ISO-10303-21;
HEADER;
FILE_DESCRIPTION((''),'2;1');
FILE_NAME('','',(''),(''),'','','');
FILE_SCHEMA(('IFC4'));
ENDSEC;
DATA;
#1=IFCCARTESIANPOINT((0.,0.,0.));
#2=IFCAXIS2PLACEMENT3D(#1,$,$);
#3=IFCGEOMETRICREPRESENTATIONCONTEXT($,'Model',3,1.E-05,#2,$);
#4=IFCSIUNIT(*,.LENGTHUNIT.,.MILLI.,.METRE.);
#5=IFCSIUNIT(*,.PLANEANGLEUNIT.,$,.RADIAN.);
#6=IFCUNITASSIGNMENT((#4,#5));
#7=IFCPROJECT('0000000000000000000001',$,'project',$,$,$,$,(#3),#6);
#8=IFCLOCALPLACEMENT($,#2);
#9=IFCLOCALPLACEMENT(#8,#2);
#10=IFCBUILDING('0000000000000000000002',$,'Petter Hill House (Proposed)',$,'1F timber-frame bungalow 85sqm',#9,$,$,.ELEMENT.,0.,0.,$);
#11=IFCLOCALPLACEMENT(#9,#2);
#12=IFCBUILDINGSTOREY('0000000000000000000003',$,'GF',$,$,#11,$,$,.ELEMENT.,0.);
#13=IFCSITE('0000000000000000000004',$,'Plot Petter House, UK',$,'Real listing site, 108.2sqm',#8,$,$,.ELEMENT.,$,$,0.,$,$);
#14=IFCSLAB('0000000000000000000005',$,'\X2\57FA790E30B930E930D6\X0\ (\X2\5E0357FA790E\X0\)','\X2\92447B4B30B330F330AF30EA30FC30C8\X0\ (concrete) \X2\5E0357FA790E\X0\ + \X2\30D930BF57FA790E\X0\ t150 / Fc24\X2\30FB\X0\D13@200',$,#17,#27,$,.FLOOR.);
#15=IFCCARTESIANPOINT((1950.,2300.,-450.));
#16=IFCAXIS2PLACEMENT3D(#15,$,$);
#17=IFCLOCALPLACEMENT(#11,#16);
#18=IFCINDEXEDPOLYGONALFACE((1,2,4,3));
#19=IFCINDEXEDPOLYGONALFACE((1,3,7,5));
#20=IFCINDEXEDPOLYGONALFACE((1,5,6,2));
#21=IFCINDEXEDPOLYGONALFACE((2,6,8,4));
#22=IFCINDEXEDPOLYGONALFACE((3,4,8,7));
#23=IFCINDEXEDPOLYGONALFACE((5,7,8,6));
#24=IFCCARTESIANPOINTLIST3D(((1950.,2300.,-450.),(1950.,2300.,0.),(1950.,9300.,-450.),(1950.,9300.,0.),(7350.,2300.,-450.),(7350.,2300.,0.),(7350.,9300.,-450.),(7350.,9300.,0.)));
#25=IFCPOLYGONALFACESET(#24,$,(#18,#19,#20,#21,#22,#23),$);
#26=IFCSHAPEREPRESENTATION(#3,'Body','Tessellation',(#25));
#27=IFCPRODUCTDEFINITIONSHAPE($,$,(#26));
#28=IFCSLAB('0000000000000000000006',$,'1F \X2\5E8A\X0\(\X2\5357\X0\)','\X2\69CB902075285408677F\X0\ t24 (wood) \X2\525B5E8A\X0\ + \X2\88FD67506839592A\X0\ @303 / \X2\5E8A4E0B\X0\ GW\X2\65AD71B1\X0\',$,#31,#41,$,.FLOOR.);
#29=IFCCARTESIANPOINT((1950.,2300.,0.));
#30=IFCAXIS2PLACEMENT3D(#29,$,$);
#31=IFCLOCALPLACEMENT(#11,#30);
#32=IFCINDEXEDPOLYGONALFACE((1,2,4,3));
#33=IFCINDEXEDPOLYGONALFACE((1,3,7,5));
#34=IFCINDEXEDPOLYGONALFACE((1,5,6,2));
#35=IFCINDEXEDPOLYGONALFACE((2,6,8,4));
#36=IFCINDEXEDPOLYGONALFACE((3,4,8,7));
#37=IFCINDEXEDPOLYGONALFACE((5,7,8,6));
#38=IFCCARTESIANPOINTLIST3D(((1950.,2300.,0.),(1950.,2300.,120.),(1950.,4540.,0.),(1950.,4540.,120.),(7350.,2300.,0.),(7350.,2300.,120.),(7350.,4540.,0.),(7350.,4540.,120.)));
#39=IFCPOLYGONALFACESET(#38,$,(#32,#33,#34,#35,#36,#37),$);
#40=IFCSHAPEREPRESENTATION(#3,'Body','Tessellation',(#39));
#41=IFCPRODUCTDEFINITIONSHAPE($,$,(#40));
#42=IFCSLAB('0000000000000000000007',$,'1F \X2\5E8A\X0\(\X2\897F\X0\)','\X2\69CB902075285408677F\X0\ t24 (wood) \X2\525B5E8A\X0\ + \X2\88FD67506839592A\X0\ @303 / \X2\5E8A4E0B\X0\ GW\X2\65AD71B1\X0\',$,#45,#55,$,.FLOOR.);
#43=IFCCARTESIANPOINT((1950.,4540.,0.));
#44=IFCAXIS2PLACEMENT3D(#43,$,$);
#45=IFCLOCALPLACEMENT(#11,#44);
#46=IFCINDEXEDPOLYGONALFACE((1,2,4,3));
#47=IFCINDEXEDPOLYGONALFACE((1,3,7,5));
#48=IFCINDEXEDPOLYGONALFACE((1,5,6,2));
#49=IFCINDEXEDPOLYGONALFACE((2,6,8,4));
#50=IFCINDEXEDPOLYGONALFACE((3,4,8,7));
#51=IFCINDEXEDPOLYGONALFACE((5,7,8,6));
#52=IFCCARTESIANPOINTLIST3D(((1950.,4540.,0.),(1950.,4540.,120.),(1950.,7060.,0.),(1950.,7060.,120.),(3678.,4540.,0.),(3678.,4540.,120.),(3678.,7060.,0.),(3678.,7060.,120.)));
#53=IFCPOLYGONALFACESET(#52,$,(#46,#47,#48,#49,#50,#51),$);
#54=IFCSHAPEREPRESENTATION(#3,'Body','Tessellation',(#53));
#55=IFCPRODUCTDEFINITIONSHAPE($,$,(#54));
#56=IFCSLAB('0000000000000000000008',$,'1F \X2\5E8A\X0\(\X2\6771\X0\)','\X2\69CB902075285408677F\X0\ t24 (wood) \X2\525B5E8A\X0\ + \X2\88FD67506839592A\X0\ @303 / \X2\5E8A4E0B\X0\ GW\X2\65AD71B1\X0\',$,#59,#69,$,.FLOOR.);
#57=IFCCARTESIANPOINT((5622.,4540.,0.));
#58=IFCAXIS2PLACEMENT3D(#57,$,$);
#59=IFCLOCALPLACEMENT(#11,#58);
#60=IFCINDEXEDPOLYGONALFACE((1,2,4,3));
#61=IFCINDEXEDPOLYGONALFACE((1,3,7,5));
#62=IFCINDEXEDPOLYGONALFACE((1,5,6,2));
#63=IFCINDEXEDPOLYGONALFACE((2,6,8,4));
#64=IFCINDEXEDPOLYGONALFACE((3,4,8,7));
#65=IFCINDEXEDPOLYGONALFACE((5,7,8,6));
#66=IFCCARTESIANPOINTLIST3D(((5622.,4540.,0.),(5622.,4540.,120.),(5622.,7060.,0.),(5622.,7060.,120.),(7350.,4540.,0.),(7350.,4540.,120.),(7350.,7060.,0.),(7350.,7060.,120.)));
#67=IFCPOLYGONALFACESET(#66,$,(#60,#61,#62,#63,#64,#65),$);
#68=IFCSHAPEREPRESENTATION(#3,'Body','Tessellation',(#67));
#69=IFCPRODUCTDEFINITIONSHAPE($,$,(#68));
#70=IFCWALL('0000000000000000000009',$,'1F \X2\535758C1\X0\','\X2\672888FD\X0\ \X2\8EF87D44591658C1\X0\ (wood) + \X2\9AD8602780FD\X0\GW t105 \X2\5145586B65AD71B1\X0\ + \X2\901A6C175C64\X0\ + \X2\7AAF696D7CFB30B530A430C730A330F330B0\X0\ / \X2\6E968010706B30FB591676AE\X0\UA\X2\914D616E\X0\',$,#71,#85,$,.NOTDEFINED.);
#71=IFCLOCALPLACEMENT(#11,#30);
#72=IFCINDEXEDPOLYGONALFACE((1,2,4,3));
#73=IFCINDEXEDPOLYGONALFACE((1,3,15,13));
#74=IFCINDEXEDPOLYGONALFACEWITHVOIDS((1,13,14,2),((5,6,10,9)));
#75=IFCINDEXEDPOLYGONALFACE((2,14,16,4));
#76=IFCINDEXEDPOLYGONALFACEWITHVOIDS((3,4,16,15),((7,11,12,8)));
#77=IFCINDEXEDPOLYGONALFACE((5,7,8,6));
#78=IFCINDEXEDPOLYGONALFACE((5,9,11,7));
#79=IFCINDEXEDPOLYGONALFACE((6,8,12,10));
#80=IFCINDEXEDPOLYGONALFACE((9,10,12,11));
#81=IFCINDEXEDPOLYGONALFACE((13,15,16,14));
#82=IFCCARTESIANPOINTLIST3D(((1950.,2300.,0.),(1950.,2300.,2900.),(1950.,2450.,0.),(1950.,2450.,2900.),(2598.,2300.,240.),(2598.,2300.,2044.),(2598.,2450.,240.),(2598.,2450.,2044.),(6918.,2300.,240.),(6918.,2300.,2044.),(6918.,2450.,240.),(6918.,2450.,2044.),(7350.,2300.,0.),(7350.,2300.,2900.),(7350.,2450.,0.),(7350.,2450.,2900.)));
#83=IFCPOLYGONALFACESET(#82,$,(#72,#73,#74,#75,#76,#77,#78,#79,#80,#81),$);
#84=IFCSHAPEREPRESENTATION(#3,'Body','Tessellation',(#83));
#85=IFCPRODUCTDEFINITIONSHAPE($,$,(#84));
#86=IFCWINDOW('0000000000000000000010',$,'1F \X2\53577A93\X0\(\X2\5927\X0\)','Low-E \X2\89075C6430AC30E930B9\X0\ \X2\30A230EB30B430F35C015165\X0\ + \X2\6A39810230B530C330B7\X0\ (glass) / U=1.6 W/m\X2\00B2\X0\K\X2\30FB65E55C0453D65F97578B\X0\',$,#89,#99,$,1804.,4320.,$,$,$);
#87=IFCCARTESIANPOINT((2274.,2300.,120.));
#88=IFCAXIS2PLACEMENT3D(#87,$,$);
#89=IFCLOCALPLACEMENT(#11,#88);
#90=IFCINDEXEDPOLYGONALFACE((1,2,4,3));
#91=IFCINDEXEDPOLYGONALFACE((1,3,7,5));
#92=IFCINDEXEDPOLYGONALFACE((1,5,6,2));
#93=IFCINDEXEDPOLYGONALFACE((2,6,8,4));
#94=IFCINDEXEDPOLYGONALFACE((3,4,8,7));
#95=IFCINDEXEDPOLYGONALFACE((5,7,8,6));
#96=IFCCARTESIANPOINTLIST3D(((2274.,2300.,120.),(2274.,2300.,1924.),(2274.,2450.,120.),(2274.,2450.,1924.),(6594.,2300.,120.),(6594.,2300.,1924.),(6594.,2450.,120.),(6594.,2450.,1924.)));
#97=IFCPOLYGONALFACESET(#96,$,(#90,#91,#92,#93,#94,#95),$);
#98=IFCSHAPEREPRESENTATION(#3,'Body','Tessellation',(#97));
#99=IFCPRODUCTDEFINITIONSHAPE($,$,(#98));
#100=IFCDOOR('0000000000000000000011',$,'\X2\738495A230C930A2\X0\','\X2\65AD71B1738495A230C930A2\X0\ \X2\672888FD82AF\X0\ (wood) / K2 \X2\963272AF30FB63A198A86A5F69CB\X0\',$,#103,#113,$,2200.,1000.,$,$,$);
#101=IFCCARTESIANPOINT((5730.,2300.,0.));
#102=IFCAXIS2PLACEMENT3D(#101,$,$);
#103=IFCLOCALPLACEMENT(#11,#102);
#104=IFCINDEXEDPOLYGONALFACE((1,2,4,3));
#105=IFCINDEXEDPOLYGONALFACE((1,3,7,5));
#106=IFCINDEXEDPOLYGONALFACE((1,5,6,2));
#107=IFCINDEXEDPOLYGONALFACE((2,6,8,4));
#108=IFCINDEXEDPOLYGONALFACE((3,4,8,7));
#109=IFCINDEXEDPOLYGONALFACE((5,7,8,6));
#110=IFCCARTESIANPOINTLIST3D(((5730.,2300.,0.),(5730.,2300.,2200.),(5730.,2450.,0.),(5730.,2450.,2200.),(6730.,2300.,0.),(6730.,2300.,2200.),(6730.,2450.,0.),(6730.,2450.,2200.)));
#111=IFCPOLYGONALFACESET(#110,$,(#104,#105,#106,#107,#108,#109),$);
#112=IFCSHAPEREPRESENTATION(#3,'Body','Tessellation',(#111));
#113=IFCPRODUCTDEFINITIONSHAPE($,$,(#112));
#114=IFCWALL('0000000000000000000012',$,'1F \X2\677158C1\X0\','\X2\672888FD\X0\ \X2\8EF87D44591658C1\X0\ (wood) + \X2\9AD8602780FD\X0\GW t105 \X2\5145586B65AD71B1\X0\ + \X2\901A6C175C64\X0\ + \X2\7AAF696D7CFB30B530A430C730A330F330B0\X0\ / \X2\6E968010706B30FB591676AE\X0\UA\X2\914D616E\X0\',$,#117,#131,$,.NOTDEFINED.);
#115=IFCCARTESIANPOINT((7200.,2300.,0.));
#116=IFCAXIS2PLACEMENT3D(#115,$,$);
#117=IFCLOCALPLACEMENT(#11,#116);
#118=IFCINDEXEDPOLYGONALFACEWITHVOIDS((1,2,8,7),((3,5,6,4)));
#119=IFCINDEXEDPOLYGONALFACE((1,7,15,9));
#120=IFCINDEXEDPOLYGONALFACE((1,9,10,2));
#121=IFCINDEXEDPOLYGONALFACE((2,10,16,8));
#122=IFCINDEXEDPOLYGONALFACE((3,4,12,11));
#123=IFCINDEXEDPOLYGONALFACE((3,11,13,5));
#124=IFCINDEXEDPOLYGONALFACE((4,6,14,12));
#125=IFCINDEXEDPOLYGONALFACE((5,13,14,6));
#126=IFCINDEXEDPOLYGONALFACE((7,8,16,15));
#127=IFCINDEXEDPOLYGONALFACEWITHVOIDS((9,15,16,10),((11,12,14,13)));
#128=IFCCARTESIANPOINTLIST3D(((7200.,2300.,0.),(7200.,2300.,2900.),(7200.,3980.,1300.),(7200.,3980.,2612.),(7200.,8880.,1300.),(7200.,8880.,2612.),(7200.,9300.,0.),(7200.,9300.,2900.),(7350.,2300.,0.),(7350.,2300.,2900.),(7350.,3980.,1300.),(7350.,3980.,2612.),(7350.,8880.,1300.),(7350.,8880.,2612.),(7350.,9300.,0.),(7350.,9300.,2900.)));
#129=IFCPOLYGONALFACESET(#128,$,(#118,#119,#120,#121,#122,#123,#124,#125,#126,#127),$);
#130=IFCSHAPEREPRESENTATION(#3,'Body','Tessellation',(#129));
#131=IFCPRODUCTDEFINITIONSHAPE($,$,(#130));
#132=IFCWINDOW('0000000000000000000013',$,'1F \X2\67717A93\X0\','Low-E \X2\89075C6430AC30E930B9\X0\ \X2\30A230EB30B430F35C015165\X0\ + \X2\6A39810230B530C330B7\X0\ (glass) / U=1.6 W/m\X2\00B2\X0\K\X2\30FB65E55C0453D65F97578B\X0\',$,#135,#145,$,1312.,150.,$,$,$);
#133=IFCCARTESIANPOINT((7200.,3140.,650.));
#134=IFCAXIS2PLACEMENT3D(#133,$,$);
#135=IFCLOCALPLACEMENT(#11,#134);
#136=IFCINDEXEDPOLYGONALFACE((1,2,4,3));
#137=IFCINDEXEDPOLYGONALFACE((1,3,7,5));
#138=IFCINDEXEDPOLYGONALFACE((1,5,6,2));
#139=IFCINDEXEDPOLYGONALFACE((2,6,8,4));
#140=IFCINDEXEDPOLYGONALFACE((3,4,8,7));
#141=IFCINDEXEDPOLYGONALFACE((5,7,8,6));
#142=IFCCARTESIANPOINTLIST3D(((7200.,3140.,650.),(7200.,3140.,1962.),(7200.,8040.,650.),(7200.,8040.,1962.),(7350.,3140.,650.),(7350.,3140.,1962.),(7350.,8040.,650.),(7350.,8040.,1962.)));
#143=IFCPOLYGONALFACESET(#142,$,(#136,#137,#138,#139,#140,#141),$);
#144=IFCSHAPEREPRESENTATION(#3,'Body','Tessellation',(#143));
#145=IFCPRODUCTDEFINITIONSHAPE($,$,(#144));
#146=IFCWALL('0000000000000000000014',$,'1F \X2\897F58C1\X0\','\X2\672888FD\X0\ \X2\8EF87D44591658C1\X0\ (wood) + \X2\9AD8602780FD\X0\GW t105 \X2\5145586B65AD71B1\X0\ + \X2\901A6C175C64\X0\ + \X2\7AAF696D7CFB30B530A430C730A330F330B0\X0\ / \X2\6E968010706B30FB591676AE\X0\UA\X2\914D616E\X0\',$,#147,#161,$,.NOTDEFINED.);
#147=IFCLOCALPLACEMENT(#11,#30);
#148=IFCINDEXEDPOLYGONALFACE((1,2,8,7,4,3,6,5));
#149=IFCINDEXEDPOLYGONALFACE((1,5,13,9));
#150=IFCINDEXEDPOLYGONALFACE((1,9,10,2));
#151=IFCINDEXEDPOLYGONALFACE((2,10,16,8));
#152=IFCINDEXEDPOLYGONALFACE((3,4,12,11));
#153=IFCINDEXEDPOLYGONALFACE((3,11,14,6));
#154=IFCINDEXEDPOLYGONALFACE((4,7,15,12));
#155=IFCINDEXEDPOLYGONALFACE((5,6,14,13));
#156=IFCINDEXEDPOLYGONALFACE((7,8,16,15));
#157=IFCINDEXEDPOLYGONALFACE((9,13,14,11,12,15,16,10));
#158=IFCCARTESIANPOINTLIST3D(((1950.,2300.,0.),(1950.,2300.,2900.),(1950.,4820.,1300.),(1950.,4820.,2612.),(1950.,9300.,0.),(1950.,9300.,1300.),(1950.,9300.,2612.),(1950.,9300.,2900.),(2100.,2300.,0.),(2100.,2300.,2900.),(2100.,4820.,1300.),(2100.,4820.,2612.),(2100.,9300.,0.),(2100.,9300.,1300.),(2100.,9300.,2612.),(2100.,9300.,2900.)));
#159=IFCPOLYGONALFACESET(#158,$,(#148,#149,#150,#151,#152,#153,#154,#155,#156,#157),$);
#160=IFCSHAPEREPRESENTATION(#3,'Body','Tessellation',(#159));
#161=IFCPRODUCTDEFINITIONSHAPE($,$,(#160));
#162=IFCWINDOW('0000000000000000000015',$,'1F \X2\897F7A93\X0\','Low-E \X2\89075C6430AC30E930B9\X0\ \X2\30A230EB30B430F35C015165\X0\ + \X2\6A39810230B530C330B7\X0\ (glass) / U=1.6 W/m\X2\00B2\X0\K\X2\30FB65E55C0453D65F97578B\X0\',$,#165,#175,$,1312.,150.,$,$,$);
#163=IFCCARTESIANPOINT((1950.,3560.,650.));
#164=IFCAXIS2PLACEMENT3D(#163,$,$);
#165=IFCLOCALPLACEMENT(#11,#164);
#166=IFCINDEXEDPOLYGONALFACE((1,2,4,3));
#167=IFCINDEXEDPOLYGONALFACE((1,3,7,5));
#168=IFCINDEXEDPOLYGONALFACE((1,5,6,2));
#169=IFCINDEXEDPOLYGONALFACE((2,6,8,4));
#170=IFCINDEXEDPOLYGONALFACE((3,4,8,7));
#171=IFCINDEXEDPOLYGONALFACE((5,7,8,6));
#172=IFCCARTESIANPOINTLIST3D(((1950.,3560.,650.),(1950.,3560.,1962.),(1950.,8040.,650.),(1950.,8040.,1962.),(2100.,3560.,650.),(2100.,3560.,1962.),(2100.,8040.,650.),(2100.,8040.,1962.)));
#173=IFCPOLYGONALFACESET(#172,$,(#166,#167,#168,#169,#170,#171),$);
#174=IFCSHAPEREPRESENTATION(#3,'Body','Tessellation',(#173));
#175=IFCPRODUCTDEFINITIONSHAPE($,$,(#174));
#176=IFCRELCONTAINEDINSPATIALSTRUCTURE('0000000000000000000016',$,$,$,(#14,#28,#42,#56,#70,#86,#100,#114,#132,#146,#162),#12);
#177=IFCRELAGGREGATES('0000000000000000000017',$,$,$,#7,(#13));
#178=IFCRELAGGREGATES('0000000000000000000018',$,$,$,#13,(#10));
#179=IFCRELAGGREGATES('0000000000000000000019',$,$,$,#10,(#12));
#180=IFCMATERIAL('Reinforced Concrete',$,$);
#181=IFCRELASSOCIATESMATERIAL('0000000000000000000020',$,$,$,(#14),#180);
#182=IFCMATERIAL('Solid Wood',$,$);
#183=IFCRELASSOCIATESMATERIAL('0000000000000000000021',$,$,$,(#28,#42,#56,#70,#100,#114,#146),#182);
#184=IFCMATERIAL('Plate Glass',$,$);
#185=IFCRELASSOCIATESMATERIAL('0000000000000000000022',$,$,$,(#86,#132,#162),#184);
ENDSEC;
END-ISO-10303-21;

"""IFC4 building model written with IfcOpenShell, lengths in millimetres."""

from ifc_helpers import new_model, si_unit, frame, frame_2d, origin, place, context, project, spatial, rectangle, extrude, material, element, fill, save


model = new_model("IFC4")

# Units and contexts
model_context = context("Model", 3, precision=1e-05, world=origin())
ifc_project = project(units=[si_unit("LENGTHUNIT", "METRE", prefix="MILLI"), si_unit("PLANEANGLEUNIT", "RADIAN")], contexts=[model_context])

# Site, building, storey
site_placement = place(None, origin())
site = spatial("IfcSite", under=ifc_project, at=site_placement, Name="Plot Petter House, UK", ObjectType="Real listing site, 108.2sqm", CompositionType="ELEMENT", RefElevation=0.0)
building_placement = place(site_placement, origin())
building = spatial("IfcBuilding", under=site, at=building_placement, Name="Petter Hill House (Proposed)", ObjectType="1F timber-frame bungalow 85sqm", CompositionType="ELEMENT", ElevationOfRefHeight=0.0, ElevationOfTerrain=0.0)
storey_placement = place(building_placement, origin())
storey = spatial("IfcBuildingStorey", under=building, at=storey_placement, Name="GF", CompositionType="ELEMENT", Elevation=0.0)

# Slabs
ifc_material_1 = material(Name="Reinforced Concrete")
slab_1_placement = place(storey_placement, frame((1950.0, 2300.0, -450.0)))
element("IfcSlab", 1, at=slab_1_placement, inside=storey, material=ifc_material_1, Name="基礎スラブ (布基礎)", Description="鉄筋コンクリート (concrete) 布基礎 + ベタ基礎 t150 / Fc24・D13@200", PredefinedType="FLOOR", context=model_context, shape_type="SweptSolid", body=[
    extrude(rectangle(XDim=5400.0, YDim=7000.0, at=frame_2d((2700.0, 3500.0))), frame((1950.0, 2300.0, -450.0)), (0.0, 0.0, 1.0), 450.0),
])
ifc_material_2 = material(Name="Solid Wood")
slab_2_placement = place(storey_placement, frame((1950.0, 2300.0, 0.0)))
element("IfcSlab", 2, at=slab_2_placement, inside=storey, material=ifc_material_2, Name="1F 床(南)", Description="構造用合板 t24 (wood) 剛床 + 製材根太 @303 / 床下 GW断熱", PredefinedType="FLOOR", context=model_context, shape_type="SweptSolid", body=[
    extrude(rectangle(XDim=5400.0, YDim=2240.0, at=frame_2d((2700.0, 1120.0))), frame((1950.0, 2300.0, 0.0)), (0.0, 0.0, 1.0), 120.0),
])
slab_3_placement = place(storey_placement, frame((1950.0, 4540.0, 0.0)))
element("IfcSlab", 3, at=slab_3_placement, inside=storey, material=ifc_material_2, Name="1F 床(西)", Description="構造用合板 t24 (wood) 剛床 + 製材根太 @303 / 床下 GW断熱", PredefinedType="FLOOR", context=model_context, shape_type="SweptSolid", body=[
    extrude(rectangle(XDim=1728.0, YDim=2520.0, at=frame_2d((864.0, 1260.0))), frame((1950.0, 4540.0, 0.0)), (0.0, 0.0, 1.0), 120.0),
])
slab_4_placement = place(storey_placement, frame((5622.0, 4540.0, 0.0)))
element("IfcSlab", 4, at=slab_4_placement, inside=storey, material=ifc_material_2, Name="1F 床(東)", Description="構造用合板 t24 (wood) 剛床 + 製材根太 @303 / 床下 GW断熱", PredefinedType="FLOOR", context=model_context, shape_type="SweptSolid", body=[
    extrude(rectangle(XDim=1728.0, YDim=2520.0, at=frame_2d((864.0, 1260.0))), frame((5622.0, 4540.0, 0.0)), (0.0, 0.0, 1.0), 120.0),
])

# Wall, openings, window, door
wall_1_placement = place(storey_placement, frame((1950.0, 2300.0, 0.0)))
wall_1 = element("IfcWall", 5, at=wall_1_placement, inside=storey, material=ifc_material_2, Name="1F 南壁", Description="木製 軸組外壁 (wood) + 高性能GW t105 充填断熱 + 通気層 + 窯業系サイディング / 準耐火・外皮UA配慮", PredefinedType="NOTDEFINED", context=model_context, shape_type="SweptSolid", body=[
    extrude(rectangle(XDim=5400.0, YDim=150.0, at=frame_2d((2700.0, 75.0))), frame((1950.0, 2300.0, 0.0)), (0.0, 0.0, 1.0), 2900.0),
])
opening_1_placement = place(storey_placement, frame((2274.0, 2300.0, 120.0)))
opening_1 = element("IfcOpeningElement", 6, at=opening_1_placement, cuts=wall_1, PredefinedType="NOTDEFINED", context=model_context, shape_type="SweptSolid", body=[
    extrude(rectangle(XDim=4320.0, YDim=150.0, at=frame_2d((2160.0, 75.0))), frame((2274.0, 2300.0, 120.0)), (0.0, 0.0, 1.0), 1804.0),
])
opening_2_placement = place(storey_placement, frame((5730.0, 2300.0, 0.0)))
opening_2 = element("IfcOpeningElement", 7, at=opening_2_placement, cuts=wall_1, PredefinedType="NOTDEFINED", context=model_context, shape_type="SweptSolid", body=[
    extrude(rectangle(XDim=1000.0, YDim=150.0, at=frame_2d((500.0, 75.0))), frame((5730.0, 2300.0, 0.0)), (0.0, 0.0, 1.0), 2200.0),
])
ifc_material_3 = material(Name="Plate Glass")
window_1_placement = place(storey_placement, frame((2274.0, 2300.0, 120.0)))
window_1 = element("IfcWindow", 8, at=window_1_placement, inside=storey, material=ifc_material_3, Name="1F 南窓(大)", Description="Low-E 複層ガラス アルゴン封入 + 樹脂サッシ (glass) / U=1.6 W/m²K・日射取得型", OverallHeight=1804.0, OverallWidth=4320.0, context=model_context, shape_type="SweptSolid", body=[
    extrude(rectangle(XDim=4320.0, YDim=150.0, at=frame_2d((2160.0, 75.0))), frame((2274.0, 2300.0, 120.0)), (0.0, 0.0, 1.0), 1804.0),
])
fill(opening_1, window_1)
door_placement = place(storey_placement, frame((5730.0, 2300.0, 0.0)))
door = element("IfcDoor", 9, at=door_placement, inside=storey, material=ifc_material_2, Name="玄関ドア", Description="断熱玄関ドア 木製芯 (wood) / K2 防犯・採風機構", OverallHeight=2200.0, OverallWidth=1000.0, context=model_context, shape_type="SweptSolid", body=[
    extrude(rectangle(XDim=1000.0, YDim=150.0, at=frame_2d((500.0, 75.0))), frame((5730.0, 2300.0, 0.0)), (0.0, 0.0, 1.0), 2200.0),
])
fill(opening_2, door)

# Walls, openings, windows
wall_2_placement = place(storey_placement, frame((7200.0, 2300.0, 0.0)))
wall_2 = element("IfcWall", 10, at=wall_2_placement, inside=storey, material=ifc_material_2, Name="1F 東壁", Description="木製 軸組外壁 (wood) + 高性能GW t105 充填断熱 + 通気層 + 窯業系サイディング / 準耐火・外皮UA配慮", PredefinedType="NOTDEFINED", context=model_context, shape_type="SweptSolid", body=[
    extrude(rectangle(XDim=150.0, YDim=7000.0, at=frame_2d((75.0, 3500.0))), frame((7200.0, 2300.0, 0.0)), (0.0, 0.0, 1.0), 2900.0),
])
opening_3_placement = place(storey_placement, frame((7200.0, 3140.0, 650.0)))
opening_3 = element("IfcOpeningElement", 11, at=opening_3_placement, cuts=wall_2, PredefinedType="NOTDEFINED", context=model_context, shape_type="SweptSolid", body=[
    extrude(rectangle(XDim=150.0, YDim=4900.0, at=frame_2d((75.0, 2450.0))), frame((7200.0, 3140.0, 650.0)), (0.0, 0.0, 1.0), 1312.0),
])
window_2_placement = place(storey_placement, frame((7200.0, 3140.0, 650.0)))
window_2 = element("IfcWindow", 12, at=window_2_placement, inside=storey, material=ifc_material_3, Name="1F 東窓", Description="Low-E 複層ガラス アルゴン封入 + 樹脂サッシ (glass) / U=1.6 W/m²K・日射取得型", OverallHeight=1312.0, OverallWidth=150.0, context=model_context, shape_type="SweptSolid", body=[
    extrude(rectangle(XDim=150.0, YDim=4900.0, at=frame_2d((75.0, 2450.0))), frame((7200.0, 3140.0, 650.0)), (0.0, 0.0, 1.0), 1312.0),
])
fill(opening_3, window_2)
wall_3_placement = place(storey_placement, frame((1950.0, 2300.0, 0.0)))
wall_3 = element("IfcWall", 13, at=wall_3_placement, inside=storey, material=ifc_material_2, Name="1F 西壁", Description="木製 軸組外壁 (wood) + 高性能GW t105 充填断熱 + 通気層 + 窯業系サイディング / 準耐火・外皮UA配慮", PredefinedType="NOTDEFINED", context=model_context, shape_type="SweptSolid", body=[
    extrude(rectangle(XDim=150.0, YDim=7000.0, at=frame_2d((75.0, 3500.0))), frame((1950.0, 2300.0, 0.0)), (0.0, 0.0, 1.0), 2900.0),
])
opening_4_placement = place(storey_placement, frame((1950.0, 3560.0, 650.0)))
opening_4 = element("IfcOpeningElement", 14, at=opening_4_placement, cuts=wall_3, PredefinedType="NOTDEFINED", context=model_context, shape_type="SweptSolid", body=[
    extrude(rectangle(XDim=150.0, YDim=4480.0, at=frame_2d((75.0, 2240.0))), frame((1950.0, 3560.0, 650.0)), (0.0, 0.0, 1.0), 1312.0),
])
window_3_placement = place(storey_placement, frame((1950.0, 3560.0, 650.0)))
window_3 = element("IfcWindow", 15, at=window_3_placement, inside=storey, material=ifc_material_3, Name="1F 西窓", Description="Low-E 複層ガラス アルゴン封入 + 樹脂サッシ (glass) / U=1.6 W/m²K・日射取得型", OverallHeight=1312.0, OverallWidth=150.0, context=model_context, shape_type="SweptSolid", body=[
    extrude(rectangle(XDim=150.0, YDim=4480.0, at=frame_2d((75.0, 2240.0))), frame((1950.0, 3560.0, 650.0)), (0.0, 0.0, 1.0), 1312.0),
])
fill(opening_4, window_3)

save(model, "model.ifc")
